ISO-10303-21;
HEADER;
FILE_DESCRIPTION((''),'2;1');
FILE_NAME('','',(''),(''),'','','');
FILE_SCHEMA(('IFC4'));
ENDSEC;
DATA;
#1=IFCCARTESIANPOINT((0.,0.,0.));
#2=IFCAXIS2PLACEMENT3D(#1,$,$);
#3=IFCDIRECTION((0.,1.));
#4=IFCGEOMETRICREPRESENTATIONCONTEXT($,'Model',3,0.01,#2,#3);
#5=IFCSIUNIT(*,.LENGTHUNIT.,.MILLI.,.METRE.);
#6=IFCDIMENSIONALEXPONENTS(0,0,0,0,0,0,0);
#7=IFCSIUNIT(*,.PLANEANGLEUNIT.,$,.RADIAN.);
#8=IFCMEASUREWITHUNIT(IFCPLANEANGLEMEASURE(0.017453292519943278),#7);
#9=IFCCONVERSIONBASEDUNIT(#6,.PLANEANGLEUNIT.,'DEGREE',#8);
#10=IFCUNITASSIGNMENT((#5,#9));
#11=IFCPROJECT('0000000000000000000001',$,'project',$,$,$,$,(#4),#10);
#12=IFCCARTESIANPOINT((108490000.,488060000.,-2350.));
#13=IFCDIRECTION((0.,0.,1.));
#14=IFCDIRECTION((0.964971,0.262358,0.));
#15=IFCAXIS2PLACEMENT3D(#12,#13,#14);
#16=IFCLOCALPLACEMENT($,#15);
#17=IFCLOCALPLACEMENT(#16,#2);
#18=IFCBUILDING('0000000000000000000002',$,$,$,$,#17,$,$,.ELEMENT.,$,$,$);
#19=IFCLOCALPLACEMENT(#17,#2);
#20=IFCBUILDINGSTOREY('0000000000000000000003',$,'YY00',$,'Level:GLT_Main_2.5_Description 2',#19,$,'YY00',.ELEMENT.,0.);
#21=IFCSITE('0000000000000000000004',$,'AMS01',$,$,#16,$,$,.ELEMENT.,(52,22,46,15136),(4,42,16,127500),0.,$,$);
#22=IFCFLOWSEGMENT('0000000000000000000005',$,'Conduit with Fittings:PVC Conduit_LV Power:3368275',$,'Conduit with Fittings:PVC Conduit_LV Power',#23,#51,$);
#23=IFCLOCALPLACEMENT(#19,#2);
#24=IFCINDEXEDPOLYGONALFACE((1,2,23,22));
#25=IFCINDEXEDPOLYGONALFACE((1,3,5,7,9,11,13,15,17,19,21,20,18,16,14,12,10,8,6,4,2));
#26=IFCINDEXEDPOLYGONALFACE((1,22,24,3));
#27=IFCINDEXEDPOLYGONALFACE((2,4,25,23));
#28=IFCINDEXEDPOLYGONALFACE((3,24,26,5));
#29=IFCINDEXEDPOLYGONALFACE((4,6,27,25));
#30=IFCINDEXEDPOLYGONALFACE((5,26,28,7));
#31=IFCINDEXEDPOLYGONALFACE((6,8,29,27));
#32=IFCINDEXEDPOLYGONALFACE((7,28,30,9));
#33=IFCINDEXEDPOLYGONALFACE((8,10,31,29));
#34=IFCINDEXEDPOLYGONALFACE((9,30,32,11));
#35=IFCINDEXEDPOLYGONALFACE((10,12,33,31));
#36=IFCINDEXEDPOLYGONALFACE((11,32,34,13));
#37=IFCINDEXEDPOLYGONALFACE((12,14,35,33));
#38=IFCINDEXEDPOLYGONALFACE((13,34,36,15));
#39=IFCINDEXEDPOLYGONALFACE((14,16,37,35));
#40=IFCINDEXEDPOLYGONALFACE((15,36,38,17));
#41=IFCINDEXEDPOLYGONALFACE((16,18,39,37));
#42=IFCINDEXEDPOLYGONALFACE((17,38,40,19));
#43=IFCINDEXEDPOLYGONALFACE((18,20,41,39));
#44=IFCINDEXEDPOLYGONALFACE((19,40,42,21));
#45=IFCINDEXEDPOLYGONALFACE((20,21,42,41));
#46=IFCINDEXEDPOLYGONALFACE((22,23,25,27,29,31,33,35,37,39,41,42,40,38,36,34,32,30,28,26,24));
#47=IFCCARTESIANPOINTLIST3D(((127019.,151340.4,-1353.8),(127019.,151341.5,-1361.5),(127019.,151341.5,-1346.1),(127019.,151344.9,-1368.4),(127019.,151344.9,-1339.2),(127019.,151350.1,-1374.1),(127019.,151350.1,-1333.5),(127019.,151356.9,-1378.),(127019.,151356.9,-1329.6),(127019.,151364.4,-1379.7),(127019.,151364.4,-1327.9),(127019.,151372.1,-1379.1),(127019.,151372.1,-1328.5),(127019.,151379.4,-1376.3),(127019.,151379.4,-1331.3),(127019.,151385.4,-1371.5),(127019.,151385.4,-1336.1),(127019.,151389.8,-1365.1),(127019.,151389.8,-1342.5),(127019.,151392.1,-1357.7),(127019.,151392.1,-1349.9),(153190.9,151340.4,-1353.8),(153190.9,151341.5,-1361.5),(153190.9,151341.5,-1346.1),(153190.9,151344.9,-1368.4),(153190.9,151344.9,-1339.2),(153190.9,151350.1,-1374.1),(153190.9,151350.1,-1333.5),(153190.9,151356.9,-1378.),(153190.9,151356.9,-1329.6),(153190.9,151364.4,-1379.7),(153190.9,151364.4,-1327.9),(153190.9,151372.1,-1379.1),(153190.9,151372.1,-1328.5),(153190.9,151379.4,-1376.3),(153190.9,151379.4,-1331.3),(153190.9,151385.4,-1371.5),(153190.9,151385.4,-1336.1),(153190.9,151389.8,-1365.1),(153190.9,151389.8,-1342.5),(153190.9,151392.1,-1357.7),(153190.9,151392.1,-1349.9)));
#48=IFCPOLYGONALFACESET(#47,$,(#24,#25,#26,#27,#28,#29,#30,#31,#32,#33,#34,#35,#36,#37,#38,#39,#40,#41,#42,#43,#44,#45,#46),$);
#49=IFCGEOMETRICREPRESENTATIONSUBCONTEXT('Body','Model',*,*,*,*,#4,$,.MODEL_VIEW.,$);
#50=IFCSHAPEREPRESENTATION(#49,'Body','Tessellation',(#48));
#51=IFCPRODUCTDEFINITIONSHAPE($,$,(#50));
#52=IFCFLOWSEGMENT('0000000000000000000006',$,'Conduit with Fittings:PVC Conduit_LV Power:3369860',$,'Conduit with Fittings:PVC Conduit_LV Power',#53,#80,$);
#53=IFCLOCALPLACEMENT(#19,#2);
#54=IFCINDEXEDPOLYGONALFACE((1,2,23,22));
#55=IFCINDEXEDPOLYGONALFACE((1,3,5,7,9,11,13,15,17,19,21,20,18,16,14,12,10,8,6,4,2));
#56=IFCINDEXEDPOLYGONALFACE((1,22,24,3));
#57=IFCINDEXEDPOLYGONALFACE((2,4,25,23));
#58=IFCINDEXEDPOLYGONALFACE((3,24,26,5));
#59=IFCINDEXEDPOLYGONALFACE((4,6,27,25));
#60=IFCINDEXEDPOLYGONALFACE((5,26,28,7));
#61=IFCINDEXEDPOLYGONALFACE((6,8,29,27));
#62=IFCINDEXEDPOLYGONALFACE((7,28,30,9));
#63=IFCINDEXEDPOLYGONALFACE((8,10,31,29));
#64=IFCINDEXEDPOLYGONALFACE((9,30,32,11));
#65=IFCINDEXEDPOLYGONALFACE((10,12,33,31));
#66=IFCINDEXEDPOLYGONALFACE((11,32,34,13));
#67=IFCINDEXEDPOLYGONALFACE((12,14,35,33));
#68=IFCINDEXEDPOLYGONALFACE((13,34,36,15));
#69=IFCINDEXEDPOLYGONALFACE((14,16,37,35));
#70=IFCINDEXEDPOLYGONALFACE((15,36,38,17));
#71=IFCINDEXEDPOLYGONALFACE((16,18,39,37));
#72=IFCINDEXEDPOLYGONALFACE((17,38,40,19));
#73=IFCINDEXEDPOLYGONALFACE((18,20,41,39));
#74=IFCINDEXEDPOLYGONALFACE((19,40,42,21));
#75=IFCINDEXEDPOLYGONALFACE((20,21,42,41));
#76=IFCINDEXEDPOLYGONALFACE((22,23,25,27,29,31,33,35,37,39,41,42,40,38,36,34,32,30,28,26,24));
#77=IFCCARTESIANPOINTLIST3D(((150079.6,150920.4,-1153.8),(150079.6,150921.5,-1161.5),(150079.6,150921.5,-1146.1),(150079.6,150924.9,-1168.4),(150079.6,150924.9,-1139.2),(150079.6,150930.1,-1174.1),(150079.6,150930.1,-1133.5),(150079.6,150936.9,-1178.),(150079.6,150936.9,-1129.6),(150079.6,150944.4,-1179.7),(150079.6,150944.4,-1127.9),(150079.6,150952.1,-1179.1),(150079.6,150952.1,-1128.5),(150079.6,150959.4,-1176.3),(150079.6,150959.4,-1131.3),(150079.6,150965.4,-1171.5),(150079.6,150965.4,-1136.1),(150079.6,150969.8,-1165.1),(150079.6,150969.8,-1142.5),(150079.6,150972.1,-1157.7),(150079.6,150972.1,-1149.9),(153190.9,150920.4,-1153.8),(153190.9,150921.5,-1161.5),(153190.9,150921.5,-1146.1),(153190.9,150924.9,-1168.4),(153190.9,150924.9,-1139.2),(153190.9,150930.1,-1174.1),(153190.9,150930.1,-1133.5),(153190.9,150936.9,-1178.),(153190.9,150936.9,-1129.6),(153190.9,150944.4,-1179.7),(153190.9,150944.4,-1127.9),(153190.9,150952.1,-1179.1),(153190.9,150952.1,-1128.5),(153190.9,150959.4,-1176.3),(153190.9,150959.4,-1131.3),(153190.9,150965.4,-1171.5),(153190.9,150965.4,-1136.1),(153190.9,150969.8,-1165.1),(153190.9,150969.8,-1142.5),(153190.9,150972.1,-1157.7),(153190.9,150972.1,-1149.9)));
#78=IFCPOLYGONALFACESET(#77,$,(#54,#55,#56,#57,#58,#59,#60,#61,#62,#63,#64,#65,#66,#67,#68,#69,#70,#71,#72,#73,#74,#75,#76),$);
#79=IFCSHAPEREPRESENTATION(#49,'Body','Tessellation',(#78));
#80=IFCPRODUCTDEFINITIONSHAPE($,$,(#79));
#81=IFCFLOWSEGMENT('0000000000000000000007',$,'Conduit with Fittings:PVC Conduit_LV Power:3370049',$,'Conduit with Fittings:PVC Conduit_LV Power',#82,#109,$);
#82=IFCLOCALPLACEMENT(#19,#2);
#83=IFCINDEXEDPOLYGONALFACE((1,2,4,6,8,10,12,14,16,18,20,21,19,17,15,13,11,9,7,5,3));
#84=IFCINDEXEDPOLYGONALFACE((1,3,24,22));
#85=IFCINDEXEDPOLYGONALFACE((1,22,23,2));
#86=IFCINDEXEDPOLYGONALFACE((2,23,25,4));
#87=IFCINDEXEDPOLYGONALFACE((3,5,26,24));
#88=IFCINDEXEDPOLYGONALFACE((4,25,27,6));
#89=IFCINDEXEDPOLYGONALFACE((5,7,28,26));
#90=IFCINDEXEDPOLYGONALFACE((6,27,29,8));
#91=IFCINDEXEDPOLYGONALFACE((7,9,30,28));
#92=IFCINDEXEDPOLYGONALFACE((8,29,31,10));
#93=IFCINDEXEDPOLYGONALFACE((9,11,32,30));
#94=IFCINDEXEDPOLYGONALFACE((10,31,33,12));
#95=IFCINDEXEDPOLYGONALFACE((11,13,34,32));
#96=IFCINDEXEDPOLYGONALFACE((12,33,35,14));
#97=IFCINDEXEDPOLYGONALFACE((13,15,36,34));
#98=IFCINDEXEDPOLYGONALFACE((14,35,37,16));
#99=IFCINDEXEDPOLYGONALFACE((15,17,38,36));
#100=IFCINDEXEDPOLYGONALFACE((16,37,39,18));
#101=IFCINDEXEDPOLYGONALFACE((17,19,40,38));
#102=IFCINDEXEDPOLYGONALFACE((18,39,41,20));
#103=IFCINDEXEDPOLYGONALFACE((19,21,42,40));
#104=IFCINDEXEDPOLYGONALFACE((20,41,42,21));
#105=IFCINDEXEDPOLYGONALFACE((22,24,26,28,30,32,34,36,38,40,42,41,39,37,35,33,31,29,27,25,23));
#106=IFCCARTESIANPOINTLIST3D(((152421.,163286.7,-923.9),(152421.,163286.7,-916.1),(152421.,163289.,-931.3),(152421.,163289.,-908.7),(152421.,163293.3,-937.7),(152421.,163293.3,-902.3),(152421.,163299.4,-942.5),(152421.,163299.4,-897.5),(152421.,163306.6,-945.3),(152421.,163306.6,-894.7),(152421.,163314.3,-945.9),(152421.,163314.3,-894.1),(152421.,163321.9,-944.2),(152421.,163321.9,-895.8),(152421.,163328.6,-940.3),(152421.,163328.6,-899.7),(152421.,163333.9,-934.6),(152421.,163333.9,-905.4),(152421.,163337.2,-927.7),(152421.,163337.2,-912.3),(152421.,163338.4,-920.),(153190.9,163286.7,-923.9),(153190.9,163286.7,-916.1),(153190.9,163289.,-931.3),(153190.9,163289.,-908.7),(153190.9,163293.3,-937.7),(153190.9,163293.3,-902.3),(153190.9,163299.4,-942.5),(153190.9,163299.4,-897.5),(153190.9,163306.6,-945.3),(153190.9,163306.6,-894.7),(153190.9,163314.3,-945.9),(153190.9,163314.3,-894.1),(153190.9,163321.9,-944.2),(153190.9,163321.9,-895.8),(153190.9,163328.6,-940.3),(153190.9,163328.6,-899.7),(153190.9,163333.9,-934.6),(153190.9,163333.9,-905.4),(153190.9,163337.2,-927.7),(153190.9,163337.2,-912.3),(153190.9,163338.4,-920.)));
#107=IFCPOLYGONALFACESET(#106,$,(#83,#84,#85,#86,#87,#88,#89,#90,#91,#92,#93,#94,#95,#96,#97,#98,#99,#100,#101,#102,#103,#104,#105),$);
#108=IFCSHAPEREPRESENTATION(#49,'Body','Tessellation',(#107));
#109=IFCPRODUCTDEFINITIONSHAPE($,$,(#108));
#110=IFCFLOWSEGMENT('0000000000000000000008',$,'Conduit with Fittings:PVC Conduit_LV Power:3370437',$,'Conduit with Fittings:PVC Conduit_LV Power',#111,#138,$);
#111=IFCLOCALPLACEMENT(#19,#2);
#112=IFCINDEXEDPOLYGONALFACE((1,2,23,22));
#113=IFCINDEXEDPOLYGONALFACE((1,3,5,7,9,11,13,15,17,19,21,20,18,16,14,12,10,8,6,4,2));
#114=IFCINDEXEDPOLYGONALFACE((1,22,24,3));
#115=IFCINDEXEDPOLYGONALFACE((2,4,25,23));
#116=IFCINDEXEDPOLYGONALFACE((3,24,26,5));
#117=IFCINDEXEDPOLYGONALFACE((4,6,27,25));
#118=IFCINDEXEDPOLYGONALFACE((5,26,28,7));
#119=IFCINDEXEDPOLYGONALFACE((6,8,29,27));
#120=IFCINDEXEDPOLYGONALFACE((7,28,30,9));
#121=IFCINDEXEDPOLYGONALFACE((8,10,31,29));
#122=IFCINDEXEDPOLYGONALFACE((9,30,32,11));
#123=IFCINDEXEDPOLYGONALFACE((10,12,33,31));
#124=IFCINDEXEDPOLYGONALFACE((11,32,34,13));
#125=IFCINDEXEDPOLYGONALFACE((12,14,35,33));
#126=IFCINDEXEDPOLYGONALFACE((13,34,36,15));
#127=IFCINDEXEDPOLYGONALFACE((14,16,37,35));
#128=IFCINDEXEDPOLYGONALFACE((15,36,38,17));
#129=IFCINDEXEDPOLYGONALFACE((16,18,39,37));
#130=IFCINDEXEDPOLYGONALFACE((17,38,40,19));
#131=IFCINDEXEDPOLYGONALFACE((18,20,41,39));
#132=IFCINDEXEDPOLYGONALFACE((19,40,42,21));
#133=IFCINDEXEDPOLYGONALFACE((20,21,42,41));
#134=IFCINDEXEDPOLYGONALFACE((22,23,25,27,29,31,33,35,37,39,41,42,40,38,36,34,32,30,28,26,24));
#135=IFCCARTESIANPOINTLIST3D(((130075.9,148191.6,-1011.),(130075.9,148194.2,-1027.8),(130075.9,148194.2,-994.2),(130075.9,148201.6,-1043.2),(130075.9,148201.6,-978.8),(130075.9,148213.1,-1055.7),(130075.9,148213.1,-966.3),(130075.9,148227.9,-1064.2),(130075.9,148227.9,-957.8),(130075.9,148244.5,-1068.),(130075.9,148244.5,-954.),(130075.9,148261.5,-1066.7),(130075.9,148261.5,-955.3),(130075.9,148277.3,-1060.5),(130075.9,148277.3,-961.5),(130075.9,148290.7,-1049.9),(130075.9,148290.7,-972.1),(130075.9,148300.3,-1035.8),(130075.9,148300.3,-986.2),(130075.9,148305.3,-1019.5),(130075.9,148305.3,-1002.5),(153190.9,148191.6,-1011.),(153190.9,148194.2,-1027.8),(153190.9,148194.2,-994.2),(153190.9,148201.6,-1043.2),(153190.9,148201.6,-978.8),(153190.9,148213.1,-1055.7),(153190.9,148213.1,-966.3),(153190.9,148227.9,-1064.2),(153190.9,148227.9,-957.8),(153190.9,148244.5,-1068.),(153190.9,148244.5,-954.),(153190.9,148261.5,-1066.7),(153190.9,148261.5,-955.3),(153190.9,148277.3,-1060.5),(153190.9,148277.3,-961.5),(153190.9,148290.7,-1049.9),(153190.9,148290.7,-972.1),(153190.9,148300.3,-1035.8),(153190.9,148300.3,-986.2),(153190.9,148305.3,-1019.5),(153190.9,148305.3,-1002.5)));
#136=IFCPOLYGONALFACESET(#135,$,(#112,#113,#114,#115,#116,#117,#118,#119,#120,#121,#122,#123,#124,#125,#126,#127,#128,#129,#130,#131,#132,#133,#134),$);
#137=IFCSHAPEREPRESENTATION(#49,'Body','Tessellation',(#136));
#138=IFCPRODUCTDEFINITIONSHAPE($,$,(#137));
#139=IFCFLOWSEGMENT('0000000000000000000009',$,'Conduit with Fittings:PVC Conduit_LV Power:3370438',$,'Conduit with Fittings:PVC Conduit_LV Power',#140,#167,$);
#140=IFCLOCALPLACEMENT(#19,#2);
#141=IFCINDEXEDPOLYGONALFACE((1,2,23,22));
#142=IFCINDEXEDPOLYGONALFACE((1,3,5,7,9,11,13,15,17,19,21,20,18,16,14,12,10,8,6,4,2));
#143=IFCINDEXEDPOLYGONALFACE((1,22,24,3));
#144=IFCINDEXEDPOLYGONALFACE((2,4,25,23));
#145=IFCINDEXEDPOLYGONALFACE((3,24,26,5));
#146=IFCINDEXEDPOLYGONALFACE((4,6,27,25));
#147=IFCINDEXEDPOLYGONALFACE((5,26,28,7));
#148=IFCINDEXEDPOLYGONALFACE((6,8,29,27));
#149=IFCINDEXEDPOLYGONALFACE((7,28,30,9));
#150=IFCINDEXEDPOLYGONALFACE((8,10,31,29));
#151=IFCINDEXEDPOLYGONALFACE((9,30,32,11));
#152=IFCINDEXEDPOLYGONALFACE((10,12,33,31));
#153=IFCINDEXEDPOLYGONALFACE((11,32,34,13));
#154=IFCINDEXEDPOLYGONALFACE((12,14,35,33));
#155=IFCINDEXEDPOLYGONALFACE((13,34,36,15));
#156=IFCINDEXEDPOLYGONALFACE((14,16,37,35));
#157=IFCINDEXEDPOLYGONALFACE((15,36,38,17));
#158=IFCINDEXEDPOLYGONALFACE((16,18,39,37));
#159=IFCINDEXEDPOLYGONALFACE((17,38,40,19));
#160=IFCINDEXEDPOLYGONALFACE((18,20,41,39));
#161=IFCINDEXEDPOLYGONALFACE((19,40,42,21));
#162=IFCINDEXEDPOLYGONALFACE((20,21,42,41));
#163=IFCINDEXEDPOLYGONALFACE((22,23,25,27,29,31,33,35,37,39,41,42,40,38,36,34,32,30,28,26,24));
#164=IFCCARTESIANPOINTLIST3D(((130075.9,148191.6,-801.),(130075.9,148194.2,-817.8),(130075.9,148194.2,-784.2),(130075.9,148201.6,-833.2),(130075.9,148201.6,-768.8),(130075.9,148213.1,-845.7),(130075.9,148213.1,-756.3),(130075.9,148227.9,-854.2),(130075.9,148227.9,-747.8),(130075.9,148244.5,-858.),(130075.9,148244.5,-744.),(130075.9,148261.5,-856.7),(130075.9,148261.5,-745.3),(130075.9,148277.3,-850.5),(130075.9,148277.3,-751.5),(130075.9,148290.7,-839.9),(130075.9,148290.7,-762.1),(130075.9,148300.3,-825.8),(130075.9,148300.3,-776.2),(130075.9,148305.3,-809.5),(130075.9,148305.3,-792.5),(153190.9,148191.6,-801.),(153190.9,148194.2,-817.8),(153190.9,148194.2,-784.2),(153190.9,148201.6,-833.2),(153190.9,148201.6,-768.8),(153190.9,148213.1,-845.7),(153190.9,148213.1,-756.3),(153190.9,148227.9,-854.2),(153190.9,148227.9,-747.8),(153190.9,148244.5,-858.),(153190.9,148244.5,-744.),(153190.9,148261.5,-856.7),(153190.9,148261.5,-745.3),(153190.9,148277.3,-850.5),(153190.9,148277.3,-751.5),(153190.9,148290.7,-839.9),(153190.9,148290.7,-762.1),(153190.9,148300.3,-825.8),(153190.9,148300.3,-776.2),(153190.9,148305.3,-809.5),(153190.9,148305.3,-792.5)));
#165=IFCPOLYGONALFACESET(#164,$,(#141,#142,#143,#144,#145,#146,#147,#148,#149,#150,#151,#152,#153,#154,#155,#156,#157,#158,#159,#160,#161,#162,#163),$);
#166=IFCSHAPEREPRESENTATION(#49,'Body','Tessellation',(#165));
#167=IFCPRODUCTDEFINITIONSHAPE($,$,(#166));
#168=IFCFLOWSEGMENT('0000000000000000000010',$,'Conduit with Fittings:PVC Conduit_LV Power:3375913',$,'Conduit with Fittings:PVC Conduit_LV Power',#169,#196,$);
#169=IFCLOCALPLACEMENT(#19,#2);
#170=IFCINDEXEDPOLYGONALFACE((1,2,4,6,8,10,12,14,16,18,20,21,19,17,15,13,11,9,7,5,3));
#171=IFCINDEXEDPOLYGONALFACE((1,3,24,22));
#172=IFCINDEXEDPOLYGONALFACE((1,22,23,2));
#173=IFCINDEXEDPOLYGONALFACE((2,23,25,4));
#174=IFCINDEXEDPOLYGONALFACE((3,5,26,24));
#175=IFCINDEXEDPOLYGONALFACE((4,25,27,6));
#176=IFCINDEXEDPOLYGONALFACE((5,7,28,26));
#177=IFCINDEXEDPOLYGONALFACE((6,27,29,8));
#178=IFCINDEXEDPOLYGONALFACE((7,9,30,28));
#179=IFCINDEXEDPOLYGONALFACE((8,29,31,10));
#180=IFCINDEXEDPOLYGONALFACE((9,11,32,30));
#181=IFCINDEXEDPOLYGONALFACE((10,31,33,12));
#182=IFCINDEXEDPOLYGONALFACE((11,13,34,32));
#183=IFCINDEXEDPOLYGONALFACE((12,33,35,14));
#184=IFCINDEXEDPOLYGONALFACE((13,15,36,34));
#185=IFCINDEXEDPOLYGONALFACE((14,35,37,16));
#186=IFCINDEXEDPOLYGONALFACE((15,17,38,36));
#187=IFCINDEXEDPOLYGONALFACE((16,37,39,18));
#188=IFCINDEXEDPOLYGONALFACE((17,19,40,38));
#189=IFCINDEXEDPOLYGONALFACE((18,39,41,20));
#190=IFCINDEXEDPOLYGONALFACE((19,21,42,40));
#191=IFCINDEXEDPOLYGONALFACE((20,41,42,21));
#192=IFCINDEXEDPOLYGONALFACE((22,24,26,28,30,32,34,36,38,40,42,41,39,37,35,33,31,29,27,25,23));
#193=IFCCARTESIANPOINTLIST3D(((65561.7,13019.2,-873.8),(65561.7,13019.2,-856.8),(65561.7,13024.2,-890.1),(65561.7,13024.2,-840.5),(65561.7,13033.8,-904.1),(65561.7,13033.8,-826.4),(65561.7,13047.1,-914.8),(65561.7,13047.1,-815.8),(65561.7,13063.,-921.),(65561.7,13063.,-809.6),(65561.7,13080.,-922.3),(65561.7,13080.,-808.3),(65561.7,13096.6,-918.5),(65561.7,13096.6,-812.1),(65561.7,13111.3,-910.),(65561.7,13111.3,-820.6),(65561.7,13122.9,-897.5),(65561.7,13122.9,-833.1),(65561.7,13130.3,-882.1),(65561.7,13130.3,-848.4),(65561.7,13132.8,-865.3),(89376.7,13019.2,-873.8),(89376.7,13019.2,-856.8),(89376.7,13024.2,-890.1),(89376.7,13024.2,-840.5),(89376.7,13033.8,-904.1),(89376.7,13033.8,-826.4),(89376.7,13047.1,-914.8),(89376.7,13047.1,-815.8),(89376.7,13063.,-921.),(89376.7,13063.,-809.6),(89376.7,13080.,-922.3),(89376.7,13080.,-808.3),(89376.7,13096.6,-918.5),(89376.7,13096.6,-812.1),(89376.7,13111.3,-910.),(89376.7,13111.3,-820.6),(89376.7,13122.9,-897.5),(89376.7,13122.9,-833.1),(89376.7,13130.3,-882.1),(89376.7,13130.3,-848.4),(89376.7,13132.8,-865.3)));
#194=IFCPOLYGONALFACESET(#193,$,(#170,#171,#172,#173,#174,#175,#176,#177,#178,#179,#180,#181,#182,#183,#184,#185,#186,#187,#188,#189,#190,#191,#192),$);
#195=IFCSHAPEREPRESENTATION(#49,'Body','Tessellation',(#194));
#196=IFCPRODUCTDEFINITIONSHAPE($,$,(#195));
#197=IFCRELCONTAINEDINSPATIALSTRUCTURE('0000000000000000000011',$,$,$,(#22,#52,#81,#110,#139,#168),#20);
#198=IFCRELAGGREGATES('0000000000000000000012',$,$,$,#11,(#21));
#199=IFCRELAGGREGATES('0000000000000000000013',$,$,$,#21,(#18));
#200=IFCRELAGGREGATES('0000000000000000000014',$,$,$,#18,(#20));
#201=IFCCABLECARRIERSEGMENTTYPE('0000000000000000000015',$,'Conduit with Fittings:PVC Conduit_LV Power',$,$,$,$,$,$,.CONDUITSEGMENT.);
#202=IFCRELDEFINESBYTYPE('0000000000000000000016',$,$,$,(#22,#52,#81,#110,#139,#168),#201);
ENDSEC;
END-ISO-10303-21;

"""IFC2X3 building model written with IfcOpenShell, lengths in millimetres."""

from ifc_helpers import new_model, entity, si_unit, converted_unit, direction, frame, frame_2d, origin, origin_2d_with_axis, place, context, subcontext, project, spatial, circle, extrude, type_object, element, save


model = new_model("IFC2X3")

# Units and contexts
model_context = context("Model", 3, precision=0.01, world=origin(), true_north=direction((0.0, 1.0)))
body_context = subcontext(model_context, "Body", "Model", "MODEL_VIEW")
ifc_project = project(units=[si_unit("LENGTHUNIT", "METRE", prefix="MILLI"), converted_unit("PLANEANGLEUNIT", "DEGREE", entity("IfcPlaneAngleMeasure", 0.017453292519943278), si_unit("PLANEANGLEUNIT", "RADIAN"), dimensions=[0, 0, 0, 0, 0, 0, 0])], contexts=[model_context])

# Site, building, storey
site_placement = place(None, frame((108490000.0, 488060000.0, -2350.0), z_axis=(0.0, 0.0, 1.0), x_axis=(0.964971, 0.262358, 0.0)))
site = spatial("IfcSite", under=ifc_project, at=site_placement, Name="AMS01", CompositionType="ELEMENT", RefLatitude=(52, 22, 46, 15136), RefLongitude=(4, 42, 16, 127500), RefElevation=0.0)
building_placement = place(site_placement, origin())
building = spatial("IfcBuilding", under=site, at=building_placement, CompositionType="ELEMENT")
storey_placement = place(building_placement, origin())
storey = spatial("IfcBuildingStorey", under=building, at=storey_placement, Name="YY00", ObjectType="Level:GLT_Main_2.5_Description 2", LongName="YY00", CompositionType="ELEMENT", Elevation=0.0)

# Flow segments
cable_carrier_segment_type = type_object("IfcCableCarrierSegmentType", Name="Conduit with Fittings:PVC Conduit_LV Power", PredefinedType="CONDUITSEGMENT")
flow_segment_1_placement = place(storey_placement, origin())
element("IfcFlowSegment", 1, at=flow_segment_1_placement, inside=storey, type_object=cable_carrier_segment_type, Name="Conduit with Fittings:PVC Conduit_LV Power:3368275", ObjectType="Conduit with Fittings:PVC Conduit_LV Power", context=body_context, shape_type="SweptSolid", body=[
    extrude(circle(Radius=26.0, at=origin_2d_with_axis()), frame((127019.0, 151366.4, -1353.8), z_axis=(1.0, 0.0, 0.0), x_axis=(0.0, -1.0, 0.0)), (0.0, 0.0, 1.0), 26171.9),
])
flow_segment_2_placement = place(storey_placement, origin())
element("IfcFlowSegment", 2, at=flow_segment_2_placement, inside=storey, type_object=cable_carrier_segment_type, Name="Conduit with Fittings:PVC Conduit_LV Power:3369860", ObjectType="Conduit with Fittings:PVC Conduit_LV Power", context=body_context, shape_type="SweptSolid", body=[
    extrude(circle(Radius=26.0, at=origin_2d_with_axis()), frame((150079.6, 150946.4, -1153.8), z_axis=(1.0, 0.0, 0.0), x_axis=(0.0, -1.0, 0.0)), (0.0, 0.0, 1.0), 3111.3),
])
flow_segment_3_placement = place(storey_placement, origin())
element("IfcFlowSegment", 3, at=flow_segment_3_placement, inside=storey, type_object=cable_carrier_segment_type, Name="Conduit with Fittings:PVC Conduit_LV Power:3370049", ObjectType="Conduit with Fittings:PVC Conduit_LV Power", context=body_context, shape_type="SweptSolid", body=[
    extrude(circle(Radius=26.0, at=frame_2d((0.0, 0.0), x_axis=(1.0, 0.0))), frame((152421.0, 163312.4, -920.0), z_axis=(1.0, 0.0, 0.0), x_axis=(0.0, 1.0, 0.0)), (0.0, 0.0, 1.0), 769.9),
])
flow_segment_4_placement = place(storey_placement, origin())
element("IfcFlowSegment", 4, at=flow_segment_4_placement, inside=storey, type_object=cable_carrier_segment_type, Name="Conduit with Fittings:PVC Conduit_LV Power:3370437", ObjectType="Conduit with Fittings:PVC Conduit_LV Power", context=body_context, shape_type="SweptSolid", body=[
    extrude(circle(Radius=57.2, at=origin_2d_with_axis()), frame((130075.9, 148248.8, -1011.0), z_axis=(1.0, 0.0, 0.0), x_axis=(0.0, -1.0, 0.0)), (0.0, 0.0, 1.0), 23115.0),
])
flow_segment_5_placement = place(storey_placement, origin())
element("IfcFlowSegment", 5, at=flow_segment_5_placement, inside=storey, type_object=cable_carrier_segment_type, Name="Conduit with Fittings:PVC Conduit_LV Power:3370438", ObjectType="Conduit with Fittings:PVC Conduit_LV Power", context=body_context, shape_type="SweptSolid", body=[
    extrude(circle(Radius=57.2, at=origin_2d_with_axis()), frame((130075.9, 148248.8, -801.0), z_axis=(1.0, 0.0, 0.0), x_axis=(0.0, -1.0, 0.0)), (0.0, 0.0, 1.0), 23115.0),
])
flow_segment_6_placement = place(storey_placement, origin())
element("IfcFlowSegment", 6, at=flow_segment_6_placement, inside=storey, type_object=cable_carrier_segment_type, Name="Conduit with Fittings:PVC Conduit_LV Power:3375913", ObjectType="Conduit with Fittings:PVC Conduit_LV Power", context=body_context, shape_type="SweptSolid", body=[
    extrude(circle(Radius=57.2, at=frame_2d((0.0, 0.0), x_axis=(1.0, 0.0))), frame((65561.7, 13075.7, -865.3), z_axis=(1.0, 0.0, 0.0), x_axis=(0.0, 1.0, 0.0)), (0.0, 0.0, 1.0), 23815.0),
])

save(model, "model.ifc")
